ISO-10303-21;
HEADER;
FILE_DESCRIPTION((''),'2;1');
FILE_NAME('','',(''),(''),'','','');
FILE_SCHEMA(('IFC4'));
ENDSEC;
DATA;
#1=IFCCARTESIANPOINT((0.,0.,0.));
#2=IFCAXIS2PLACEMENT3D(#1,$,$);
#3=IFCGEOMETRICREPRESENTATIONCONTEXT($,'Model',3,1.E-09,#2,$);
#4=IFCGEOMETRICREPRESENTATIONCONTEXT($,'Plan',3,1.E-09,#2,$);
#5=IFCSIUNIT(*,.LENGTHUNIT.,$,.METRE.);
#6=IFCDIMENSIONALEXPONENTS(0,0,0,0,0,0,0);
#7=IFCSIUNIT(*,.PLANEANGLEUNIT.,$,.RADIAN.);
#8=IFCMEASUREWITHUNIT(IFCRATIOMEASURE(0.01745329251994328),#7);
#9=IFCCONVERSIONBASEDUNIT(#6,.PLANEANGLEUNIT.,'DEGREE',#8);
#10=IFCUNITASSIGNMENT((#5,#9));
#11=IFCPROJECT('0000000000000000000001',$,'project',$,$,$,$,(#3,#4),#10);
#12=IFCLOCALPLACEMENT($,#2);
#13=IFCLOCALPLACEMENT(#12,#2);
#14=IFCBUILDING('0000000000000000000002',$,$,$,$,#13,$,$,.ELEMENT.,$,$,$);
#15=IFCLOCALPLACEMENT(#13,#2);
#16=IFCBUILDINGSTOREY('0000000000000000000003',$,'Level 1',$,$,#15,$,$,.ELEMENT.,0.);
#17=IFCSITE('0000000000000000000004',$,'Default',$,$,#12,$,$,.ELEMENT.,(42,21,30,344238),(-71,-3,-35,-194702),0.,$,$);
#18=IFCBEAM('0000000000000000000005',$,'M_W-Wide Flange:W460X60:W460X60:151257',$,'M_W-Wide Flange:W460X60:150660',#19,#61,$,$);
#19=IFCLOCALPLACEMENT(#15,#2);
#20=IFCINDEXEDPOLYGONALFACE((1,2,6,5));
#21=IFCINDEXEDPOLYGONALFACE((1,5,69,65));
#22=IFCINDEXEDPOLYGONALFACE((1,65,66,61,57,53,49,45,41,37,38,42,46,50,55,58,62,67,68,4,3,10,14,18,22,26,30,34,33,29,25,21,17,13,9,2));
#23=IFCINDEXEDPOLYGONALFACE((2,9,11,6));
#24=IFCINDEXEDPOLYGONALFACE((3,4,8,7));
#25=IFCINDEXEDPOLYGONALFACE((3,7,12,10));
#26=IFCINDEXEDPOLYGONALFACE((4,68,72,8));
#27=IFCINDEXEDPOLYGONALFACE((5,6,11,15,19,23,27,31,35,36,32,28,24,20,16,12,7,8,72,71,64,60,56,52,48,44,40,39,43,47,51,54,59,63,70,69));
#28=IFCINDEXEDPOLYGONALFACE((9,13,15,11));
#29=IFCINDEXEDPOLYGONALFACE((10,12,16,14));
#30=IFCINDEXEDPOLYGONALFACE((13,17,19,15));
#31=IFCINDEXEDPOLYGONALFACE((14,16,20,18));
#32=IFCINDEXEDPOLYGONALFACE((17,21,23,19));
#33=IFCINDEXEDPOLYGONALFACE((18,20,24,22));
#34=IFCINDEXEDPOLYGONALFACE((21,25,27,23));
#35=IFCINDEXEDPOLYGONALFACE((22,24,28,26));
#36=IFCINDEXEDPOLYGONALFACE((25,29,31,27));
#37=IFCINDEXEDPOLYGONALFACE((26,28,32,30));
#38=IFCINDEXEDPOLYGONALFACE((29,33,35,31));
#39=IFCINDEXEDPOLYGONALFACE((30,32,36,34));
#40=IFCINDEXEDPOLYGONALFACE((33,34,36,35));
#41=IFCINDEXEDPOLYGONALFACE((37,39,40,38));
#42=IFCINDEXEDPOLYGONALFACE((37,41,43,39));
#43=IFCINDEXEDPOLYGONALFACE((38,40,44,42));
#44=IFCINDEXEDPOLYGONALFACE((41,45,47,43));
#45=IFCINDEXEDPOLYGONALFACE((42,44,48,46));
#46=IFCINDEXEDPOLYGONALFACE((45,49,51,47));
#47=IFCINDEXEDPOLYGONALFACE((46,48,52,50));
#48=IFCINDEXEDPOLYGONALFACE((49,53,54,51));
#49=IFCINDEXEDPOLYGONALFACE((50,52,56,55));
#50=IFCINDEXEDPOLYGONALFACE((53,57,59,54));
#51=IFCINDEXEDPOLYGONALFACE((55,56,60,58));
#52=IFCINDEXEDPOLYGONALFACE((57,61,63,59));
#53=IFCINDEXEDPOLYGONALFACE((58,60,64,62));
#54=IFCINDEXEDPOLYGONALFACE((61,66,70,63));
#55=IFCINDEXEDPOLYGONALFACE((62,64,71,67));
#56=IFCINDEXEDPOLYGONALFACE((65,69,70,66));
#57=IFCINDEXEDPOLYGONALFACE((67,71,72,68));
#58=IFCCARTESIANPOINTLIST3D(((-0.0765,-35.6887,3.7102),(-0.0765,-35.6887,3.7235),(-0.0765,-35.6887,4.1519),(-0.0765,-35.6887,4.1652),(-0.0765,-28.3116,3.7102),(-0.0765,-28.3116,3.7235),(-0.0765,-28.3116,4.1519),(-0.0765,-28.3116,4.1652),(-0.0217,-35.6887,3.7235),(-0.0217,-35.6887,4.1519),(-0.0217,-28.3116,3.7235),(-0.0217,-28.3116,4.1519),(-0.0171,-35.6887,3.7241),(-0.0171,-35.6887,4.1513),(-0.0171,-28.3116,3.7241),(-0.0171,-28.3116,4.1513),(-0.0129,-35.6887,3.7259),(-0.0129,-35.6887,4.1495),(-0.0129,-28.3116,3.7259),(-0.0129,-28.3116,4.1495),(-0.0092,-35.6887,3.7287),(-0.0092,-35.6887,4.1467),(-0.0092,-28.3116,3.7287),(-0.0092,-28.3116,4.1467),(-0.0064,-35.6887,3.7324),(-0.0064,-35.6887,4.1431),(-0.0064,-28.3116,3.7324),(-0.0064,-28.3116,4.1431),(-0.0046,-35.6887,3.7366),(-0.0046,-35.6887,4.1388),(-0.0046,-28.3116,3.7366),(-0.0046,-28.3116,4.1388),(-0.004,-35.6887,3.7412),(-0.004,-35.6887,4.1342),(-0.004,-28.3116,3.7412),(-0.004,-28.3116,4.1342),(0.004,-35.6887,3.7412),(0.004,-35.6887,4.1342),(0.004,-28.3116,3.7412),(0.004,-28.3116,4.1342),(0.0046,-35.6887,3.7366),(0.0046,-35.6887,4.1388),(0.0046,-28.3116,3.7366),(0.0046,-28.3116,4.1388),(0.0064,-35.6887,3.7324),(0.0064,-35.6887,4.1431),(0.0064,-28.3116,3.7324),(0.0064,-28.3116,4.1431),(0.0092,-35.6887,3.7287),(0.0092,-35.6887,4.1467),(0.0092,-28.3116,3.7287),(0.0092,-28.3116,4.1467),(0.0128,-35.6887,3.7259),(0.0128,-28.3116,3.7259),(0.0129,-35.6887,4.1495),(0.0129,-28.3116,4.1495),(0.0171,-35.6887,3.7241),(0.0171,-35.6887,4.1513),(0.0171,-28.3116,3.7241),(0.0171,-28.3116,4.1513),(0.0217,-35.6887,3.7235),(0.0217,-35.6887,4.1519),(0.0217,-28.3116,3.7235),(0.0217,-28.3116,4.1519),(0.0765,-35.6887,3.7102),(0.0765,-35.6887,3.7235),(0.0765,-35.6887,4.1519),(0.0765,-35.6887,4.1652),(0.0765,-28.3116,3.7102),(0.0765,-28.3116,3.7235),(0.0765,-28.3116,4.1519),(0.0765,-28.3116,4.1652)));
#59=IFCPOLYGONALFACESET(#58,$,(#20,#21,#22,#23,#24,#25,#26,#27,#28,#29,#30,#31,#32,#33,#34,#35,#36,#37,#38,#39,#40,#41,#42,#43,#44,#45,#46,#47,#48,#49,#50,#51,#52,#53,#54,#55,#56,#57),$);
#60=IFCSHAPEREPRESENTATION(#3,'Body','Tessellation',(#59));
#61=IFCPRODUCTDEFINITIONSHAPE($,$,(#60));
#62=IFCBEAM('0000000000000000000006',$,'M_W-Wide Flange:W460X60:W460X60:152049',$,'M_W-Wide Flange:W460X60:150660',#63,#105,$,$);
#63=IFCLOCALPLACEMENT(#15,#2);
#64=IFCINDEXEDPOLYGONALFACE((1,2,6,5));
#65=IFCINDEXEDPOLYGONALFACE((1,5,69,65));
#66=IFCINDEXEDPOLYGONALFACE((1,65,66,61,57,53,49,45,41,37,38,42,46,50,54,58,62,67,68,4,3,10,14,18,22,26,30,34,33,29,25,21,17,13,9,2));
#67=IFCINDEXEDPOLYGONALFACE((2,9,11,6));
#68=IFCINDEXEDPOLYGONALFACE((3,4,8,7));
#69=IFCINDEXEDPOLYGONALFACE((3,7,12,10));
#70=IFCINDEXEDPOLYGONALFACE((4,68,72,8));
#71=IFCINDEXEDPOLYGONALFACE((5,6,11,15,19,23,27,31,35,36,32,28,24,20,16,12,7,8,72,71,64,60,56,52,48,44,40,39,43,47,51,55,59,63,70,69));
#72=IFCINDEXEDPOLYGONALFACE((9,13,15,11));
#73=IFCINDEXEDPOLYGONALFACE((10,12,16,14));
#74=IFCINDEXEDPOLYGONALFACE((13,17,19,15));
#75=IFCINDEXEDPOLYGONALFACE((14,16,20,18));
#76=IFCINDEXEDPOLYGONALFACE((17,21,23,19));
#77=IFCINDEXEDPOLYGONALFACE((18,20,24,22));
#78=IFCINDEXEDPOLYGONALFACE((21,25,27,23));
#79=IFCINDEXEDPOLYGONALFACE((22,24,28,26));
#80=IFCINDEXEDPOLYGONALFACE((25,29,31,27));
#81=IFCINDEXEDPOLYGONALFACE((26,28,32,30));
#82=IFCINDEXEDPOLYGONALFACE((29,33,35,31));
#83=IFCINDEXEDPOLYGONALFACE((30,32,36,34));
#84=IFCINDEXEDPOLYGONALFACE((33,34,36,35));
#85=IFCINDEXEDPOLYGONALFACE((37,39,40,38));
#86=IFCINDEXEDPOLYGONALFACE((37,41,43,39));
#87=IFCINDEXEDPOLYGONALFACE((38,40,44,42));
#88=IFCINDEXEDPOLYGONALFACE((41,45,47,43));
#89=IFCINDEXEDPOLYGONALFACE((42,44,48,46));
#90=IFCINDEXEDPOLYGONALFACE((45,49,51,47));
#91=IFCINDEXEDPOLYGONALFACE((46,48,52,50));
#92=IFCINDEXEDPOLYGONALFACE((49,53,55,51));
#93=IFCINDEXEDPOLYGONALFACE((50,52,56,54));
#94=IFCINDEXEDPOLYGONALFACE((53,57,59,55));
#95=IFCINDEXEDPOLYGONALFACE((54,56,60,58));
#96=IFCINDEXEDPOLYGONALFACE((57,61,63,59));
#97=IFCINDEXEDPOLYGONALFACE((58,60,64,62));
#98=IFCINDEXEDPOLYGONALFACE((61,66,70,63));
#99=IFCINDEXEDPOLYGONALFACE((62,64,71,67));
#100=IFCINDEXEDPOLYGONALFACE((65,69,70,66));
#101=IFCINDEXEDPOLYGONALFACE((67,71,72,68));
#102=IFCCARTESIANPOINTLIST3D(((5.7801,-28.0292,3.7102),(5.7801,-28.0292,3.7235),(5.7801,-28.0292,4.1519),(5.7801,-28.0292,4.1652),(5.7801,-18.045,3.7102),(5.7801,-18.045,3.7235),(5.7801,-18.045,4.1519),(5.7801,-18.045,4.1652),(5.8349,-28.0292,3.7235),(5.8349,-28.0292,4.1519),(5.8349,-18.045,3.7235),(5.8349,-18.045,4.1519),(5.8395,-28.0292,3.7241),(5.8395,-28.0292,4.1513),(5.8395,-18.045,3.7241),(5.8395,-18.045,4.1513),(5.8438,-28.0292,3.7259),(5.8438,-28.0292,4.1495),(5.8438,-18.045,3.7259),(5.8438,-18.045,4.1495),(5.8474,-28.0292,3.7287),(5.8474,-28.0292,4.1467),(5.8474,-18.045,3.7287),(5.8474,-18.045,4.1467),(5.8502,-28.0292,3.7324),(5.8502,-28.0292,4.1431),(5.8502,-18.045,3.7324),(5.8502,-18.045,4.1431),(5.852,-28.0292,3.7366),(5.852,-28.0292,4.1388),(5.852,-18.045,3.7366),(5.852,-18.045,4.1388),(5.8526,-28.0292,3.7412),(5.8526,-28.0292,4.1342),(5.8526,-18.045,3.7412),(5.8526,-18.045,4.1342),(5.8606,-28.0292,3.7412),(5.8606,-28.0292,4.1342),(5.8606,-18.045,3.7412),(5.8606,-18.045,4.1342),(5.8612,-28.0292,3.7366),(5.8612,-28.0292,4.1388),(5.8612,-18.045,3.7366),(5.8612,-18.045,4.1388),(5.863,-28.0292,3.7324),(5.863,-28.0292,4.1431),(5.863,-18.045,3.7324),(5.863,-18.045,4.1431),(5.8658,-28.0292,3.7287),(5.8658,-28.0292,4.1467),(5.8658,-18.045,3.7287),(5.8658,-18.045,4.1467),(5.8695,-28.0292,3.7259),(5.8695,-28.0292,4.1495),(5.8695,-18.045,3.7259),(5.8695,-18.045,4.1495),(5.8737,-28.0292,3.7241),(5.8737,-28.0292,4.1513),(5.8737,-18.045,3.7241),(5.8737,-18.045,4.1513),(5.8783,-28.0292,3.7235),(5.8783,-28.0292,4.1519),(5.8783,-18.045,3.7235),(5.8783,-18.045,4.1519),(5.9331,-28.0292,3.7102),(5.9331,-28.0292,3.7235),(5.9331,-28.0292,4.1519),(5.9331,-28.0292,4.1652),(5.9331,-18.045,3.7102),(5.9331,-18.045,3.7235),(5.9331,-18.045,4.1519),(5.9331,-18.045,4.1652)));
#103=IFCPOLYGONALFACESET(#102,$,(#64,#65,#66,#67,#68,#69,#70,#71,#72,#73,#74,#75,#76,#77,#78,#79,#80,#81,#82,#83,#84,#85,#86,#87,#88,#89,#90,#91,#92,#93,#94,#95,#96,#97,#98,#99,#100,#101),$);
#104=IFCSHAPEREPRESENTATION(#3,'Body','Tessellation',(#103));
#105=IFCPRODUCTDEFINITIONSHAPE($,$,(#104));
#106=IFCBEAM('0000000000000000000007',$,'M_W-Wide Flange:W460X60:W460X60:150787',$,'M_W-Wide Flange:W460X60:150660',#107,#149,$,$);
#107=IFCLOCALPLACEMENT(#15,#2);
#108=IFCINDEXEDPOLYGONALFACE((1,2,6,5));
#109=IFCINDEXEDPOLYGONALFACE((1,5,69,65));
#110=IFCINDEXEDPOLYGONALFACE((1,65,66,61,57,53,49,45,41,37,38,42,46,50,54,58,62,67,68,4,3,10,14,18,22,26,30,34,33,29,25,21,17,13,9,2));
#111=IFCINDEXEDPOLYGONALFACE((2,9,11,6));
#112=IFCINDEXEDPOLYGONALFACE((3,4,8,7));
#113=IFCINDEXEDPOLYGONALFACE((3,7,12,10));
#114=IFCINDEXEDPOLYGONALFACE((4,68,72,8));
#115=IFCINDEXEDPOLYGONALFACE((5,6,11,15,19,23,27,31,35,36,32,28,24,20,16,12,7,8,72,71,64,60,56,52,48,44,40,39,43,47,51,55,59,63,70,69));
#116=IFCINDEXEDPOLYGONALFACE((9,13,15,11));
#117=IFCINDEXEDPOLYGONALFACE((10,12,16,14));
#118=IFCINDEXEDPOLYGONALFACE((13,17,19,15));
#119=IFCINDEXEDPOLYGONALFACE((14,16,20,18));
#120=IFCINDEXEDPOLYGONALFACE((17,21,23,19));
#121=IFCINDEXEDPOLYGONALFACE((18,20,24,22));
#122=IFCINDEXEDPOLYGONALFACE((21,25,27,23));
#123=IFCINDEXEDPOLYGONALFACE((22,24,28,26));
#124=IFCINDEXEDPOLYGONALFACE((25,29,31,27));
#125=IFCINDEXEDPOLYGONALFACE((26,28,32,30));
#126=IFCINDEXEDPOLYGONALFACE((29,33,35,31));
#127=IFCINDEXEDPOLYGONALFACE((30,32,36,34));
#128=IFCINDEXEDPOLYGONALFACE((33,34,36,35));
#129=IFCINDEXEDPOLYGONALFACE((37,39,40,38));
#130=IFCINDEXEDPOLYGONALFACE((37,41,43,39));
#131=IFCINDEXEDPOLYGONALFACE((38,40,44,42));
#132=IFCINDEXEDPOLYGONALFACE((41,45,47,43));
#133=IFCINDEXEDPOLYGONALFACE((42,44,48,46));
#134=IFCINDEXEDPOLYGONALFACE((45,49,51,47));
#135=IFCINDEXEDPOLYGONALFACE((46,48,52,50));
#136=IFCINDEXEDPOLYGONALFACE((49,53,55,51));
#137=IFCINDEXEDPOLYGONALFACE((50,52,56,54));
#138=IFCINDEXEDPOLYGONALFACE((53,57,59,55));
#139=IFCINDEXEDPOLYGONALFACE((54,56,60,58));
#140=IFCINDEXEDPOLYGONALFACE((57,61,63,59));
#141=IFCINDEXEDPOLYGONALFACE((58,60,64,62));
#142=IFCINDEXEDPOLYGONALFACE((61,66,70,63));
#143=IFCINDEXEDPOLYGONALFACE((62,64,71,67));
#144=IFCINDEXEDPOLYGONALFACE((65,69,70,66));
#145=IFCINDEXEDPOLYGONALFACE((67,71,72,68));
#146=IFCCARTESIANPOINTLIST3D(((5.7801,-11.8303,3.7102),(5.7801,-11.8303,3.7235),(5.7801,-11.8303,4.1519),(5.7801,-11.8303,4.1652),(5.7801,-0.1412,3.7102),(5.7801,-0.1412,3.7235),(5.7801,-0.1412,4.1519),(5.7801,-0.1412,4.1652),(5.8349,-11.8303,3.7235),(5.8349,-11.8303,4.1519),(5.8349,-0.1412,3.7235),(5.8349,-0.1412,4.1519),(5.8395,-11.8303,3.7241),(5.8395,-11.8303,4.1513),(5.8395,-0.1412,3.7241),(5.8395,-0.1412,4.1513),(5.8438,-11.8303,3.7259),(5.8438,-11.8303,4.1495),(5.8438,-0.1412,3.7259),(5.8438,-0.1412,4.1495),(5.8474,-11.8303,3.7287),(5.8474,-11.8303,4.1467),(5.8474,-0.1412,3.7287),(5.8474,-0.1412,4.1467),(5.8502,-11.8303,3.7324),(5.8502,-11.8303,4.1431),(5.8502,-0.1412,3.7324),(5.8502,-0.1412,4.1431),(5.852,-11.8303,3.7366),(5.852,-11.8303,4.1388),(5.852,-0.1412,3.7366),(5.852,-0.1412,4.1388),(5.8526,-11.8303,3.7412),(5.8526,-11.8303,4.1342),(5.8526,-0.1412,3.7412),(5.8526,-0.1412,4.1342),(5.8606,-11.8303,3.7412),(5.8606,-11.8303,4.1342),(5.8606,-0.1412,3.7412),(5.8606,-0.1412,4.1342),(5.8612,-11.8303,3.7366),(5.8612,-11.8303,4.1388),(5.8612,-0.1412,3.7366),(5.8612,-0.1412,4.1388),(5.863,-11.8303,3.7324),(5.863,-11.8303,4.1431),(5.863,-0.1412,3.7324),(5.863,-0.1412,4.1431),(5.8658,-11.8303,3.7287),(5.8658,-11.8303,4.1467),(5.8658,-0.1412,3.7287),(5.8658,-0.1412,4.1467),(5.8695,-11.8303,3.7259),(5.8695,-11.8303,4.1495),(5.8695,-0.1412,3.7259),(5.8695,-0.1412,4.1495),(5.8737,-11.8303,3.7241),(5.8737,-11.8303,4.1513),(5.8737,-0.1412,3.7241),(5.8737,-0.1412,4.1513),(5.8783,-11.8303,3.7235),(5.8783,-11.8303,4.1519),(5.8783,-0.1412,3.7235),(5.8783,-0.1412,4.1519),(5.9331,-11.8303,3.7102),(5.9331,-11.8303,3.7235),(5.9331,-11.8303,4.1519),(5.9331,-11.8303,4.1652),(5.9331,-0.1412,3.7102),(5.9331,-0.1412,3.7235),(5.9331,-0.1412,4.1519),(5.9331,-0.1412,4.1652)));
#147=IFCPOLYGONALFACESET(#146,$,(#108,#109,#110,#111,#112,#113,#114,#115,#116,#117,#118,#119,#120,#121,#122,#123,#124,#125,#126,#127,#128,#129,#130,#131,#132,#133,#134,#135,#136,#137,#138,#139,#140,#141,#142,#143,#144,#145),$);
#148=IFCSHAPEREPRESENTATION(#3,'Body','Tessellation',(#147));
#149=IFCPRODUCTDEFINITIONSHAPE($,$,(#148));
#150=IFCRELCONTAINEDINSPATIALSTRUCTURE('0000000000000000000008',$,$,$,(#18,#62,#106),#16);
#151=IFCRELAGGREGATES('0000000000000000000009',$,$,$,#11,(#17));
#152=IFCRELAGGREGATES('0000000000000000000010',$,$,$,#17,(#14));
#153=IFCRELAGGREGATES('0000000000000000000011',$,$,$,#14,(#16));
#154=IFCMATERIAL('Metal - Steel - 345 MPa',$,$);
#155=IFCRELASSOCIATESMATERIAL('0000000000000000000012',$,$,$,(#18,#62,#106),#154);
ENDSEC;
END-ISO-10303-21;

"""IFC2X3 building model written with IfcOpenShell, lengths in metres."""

from ifc_helpers import new_model, entity, si_unit, converted_unit, frame, frame_2d, origin, place, context, project, spatial, polyline, circle_curve, parameter, trimmed, segment, composite_curve, outline, extrude, material, element, save


model = new_model("IFC2X3")

# Units and contexts
model_context = context("Model", 3, precision=1e-09, world=origin())
plan_context = context("Plan", 3, precision=1e-09, world=origin())
ifc_project = project(units=[si_unit("LENGTHUNIT", "METRE"), converted_unit("PLANEANGLEUNIT", "DEGREE", entity("IfcRatioMeasure", 0.01745329251994328), si_unit("PLANEANGLEUNIT", "RADIAN"), dimensions=[0, 0, 0, 0, 0, 0, 0])], contexts=[model_context, plan_context])

# Site, building, storey
site_placement = place(None, origin())
site = spatial("IfcSite", under=ifc_project, at=site_placement, Name="Default", CompositionType="ELEMENT", RefLatitude=(42, 21, 30, 344238), RefLongitude=(-71, -3, -35, -194702), RefElevation=0.0)
building_placement = place(site_placement, origin())
building = spatial("IfcBuilding", under=site, at=building_placement, CompositionType="ELEMENT")
storey_placement = place(building_placement, origin())
storey = spatial("IfcBuildingStorey", under=building, at=storey_placement, Name="Level 1", CompositionType="ELEMENT", Elevation=0.0)

# Beams
ifc_material_1 = material(Name="Metal - Steel - 345 MPa")
beam_1_placement = place(storey_placement, frame((0.0, -35.8299, 4.2672)))
element("IfcBeam", 1, at=beam_1_placement, inside=storey, material=ifc_material_1, Name="M_W-Wide Flange:W460X60:W460X60:151257", ObjectType="M_W-Wide Flange:W460X60:150660", context=model_context, shape_type="SweptSolid", body=[
    extrude(outline(composite_curve([segment(polyline([(-0.0765, -0.2142), (-0.0765, -0.2275)]), True, "CONTINUOUS"), segment(polyline([(-0.0765, -0.2275), (0.0765, -0.2275)]), True, "CONTINUOUS"), segment(polyline([(0.0765, -0.2275), (0.0765, -0.2142)]), True, "CONTINUOUS"), segment(polyline([(0.0765, -0.2142), (0.0217, -0.2142)]), True, "CONTINUOUS"), segment(trimmed(circle_curve(frame_2d((0.0217, -0.1965), x_axis=(0.0, -1.0)), 0.0177), [parameter(270.0)], [parameter(360.0)], True, "PARAMETER"), False, "CONTINUOUS"), segment(polyline([(0.004, -0.1965), (0.004, 0.1965)]), True, "CONTINUOUS"), segment(trimmed(circle_curve(frame_2d((0.0217, 0.1965), x_axis=(-1.0, 0.0)), 0.0177), [parameter(270.0)], [parameter(360.0)], True, "PARAMETER"), False, "CONTINUOUS"), segment(polyline([(0.0217, 0.2142), (0.0765, 0.2142)]), True, "CONTINUOUS"), segment(polyline([(0.0765, 0.2142), (0.0765, 0.2275)]), True, "CONTINUOUS"), segment(polyline([(0.0765, 0.2275), (-0.0765, 0.2275)]), True, "CONTINUOUS"), segment(polyline([(-0.0765, 0.2275), (-0.0765, 0.2142)]), True, "CONTINUOUS"), segment(polyline([(-0.0765, 0.2142), (-0.0217, 0.2142)]), True, "CONTINUOUS"), segment(trimmed(circle_curve(frame_2d((-0.0217, 0.1965), x_axis=(0.0, 1.0)), 0.0177), [parameter(270.0)], [parameter(360.0)], True, "PARAMETER"), False, "CONTINUOUS"), segment(polyline([(-0.004, 0.1965), (-0.004, -0.1965)]), True, "CONTINUOUS"), segment(trimmed(circle_curve(frame_2d((-0.0217, -0.1965), x_axis=(1.0, 0.0)), 0.0177), [parameter(270.0)], [parameter(0.0)], True, "PARAMETER"), False, "CONTINUOUS"), segment(polyline([(-0.0217, -0.2142), (-0.0765, -0.2142)]), True, "CONTINUOUS")], self_intersect=False)), frame((0.0, 0.1412, -0.3295), z_axis=(0.0, -1.0, 0.0), x_axis=(1.0, 0.0, 0.0)), (0.0, 0.0, -1.0), 7.3771),
])
beam_2_placement = place(storey_placement, frame((5.8566, -28.1704, 4.2672)))
element("IfcBeam", 2, at=beam_2_placement, inside=storey, material=ifc_material_1, Name="M_W-Wide Flange:W460X60:W460X60:152049", ObjectType="M_W-Wide Flange:W460X60:150660", context=model_context, shape_type="SweptSolid", body=[
    extrude(outline(composite_curve([segment(polyline([(-0.0765, -0.2142), (-0.0765, -0.2275)]), True, "CONTINUOUS"), segment(polyline([(-0.0765, -0.2275), (0.0765, -0.2275)]), True, "CONTINUOUS"), segment(polyline([(0.0765, -0.2275), (0.0765, -0.2142)]), True, "CONTINUOUS"), segment(polyline([(0.0765, -0.2142), (0.0217, -0.2142)]), True, "CONTINUOUS"), segment(trimmed(circle_curve(frame_2d((0.0217, -0.1965), x_axis=(0.0, -1.0)), 0.0177), [parameter(270.0)], [parameter(360.0)], True, "PARAMETER"), False, "CONTINUOUS"), segment(polyline([(0.004, -0.1965), (0.004, 0.1965)]), True, "CONTINUOUS"), segment(trimmed(circle_curve(frame_2d((0.0217, 0.1965), x_axis=(-1.0, 0.0)), 0.0177), [parameter(270.0)], [parameter(360.0)], True, "PARAMETER"), False, "CONTINUOUS"), segment(polyline([(0.0217, 0.2142), (0.0765, 0.2142)]), True, "CONTINUOUS"), segment(polyline([(0.0765, 0.2142), (0.0765, 0.2275)]), True, "CONTINUOUS"), segment(polyline([(0.0765, 0.2275), (-0.0765, 0.2275)]), True, "CONTINUOUS"), segment(polyline([(-0.0765, 0.2275), (-0.0765, 0.2142)]), True, "CONTINUOUS"), segment(polyline([(-0.0765, 0.2142), (-0.0217, 0.2142)]), True, "CONTINUOUS"), segment(trimmed(circle_curve(frame_2d((-0.0217, 0.1965), x_axis=(0.0, 1.0)), 0.0177), [parameter(270.0)], [parameter(360.0)], True, "PARAMETER"), False, "CONTINUOUS"), segment(polyline([(-0.004, 0.1965), (-0.004, -0.1965)]), True, "CONTINUOUS"), segment(trimmed(circle_curve(frame_2d((-0.0217, -0.1965), x_axis=(1.0, 0.0)), 0.0177), [parameter(270.0)], [parameter(0.0)], True, "PARAMETER"), False, "CONTINUOUS"), segment(polyline([(-0.0217, -0.2142), (-0.0765, -0.2142)]), True, "CONTINUOUS")], self_intersect=False)), frame((0.0, 0.1412, -0.3295), z_axis=(0.0, -1.0, 0.0), x_axis=(1.0, 0.0, 0.0)), (0.0, 0.0, -1.0), 9.9841),
])
beam_3_placement = place(storey_placement, frame((5.8566, 0.0, 4.2672), z_axis=(0.0, 0.0, 1.0), x_axis=(-1.0, 0.0, 0.0)))
element("IfcBeam", 3, at=beam_3_placement, inside=storey, material=ifc_material_1, Name="M_W-Wide Flange:W460X60:W460X60:150787", ObjectType="M_W-Wide Flange:W460X60:150660", context=model_context, shape_type="SweptSolid", body=[
    extrude(outline(composite_curve([segment(polyline([(0.2142, -0.0765), (0.2275, -0.0765)]), True, "CONTINUOUS"), segment(polyline([(0.2275, -0.0765), (0.2275, 0.0765)]), True, "CONTINUOUS"), segment(polyline([(0.2275, 0.0765), (0.2142, 0.0765)]), True, "CONTINUOUS"), segment(polyline([(0.2142, 0.0765), (0.2142, 0.0217)]), True, "CONTINUOUS"), segment(trimmed(circle_curve(frame_2d((0.1965, 0.0217), x_axis=(0.0, 1.0)), 0.0177), [parameter(180.0)], [parameter(270.0)], True, "PARAMETER"), False, "CONTINUOUS"), segment(polyline([(0.1965, 0.004), (-0.1965, 0.004)]), True, "CONTINUOUS"), segment(trimmed(circle_curve(frame_2d((-0.1965, 0.0217), x_axis=(0.0, 1.0)), 0.0177), [parameter(90.0)], [parameter(180.0)], True, "PARAMETER"), False, "CONTINUOUS"), segment(polyline([(-0.2142, 0.0217), (-0.2142, 0.0765)]), True, "CONTINUOUS"), segment(polyline([(-0.2142, 0.0765), (-0.2275, 0.0765)]), True, "CONTINUOUS"), segment(polyline([(-0.2275, 0.0765), (-0.2275, -0.0765)]), True, "CONTINUOUS"), segment(polyline([(-0.2275, -0.0765), (-0.2142, -0.0765)]), True, "CONTINUOUS"), segment(polyline([(-0.2142, -0.0765), (-0.2142, -0.0217)]), True, "CONTINUOUS"), segment(trimmed(circle_curve(frame_2d((-0.1965, -0.0217), x_axis=(0.0, 1.0)), 0.0177), [parameter(360.0)], [parameter(90.0)], True, "PARAMETER"), False, "CONTINUOUS"), segment(polyline([(-0.1965, -0.004), (0.1965, -0.004)]), True, "CONTINUOUS"), segment(trimmed(circle_curve(frame_2d((0.1965, -0.0217), x_axis=(0.0, 1.0)), 0.0177), [parameter(270.0)], [parameter(0.0)], True, "PARAMETER"), False, "CONTINUOUS"), segment(polyline([(0.2142, -0.0217), (0.2142, -0.0765)]), True, "CONTINUOUS")], self_intersect=False)), frame((0.0, 11.8303, -0.3295), z_axis=(0.0, -1.0, 0.0), x_axis=(0.0, 0.0, -1.0)), (0.0, 0.0, 1.0), 11.6891),
])

save(model, "model.ifc")
